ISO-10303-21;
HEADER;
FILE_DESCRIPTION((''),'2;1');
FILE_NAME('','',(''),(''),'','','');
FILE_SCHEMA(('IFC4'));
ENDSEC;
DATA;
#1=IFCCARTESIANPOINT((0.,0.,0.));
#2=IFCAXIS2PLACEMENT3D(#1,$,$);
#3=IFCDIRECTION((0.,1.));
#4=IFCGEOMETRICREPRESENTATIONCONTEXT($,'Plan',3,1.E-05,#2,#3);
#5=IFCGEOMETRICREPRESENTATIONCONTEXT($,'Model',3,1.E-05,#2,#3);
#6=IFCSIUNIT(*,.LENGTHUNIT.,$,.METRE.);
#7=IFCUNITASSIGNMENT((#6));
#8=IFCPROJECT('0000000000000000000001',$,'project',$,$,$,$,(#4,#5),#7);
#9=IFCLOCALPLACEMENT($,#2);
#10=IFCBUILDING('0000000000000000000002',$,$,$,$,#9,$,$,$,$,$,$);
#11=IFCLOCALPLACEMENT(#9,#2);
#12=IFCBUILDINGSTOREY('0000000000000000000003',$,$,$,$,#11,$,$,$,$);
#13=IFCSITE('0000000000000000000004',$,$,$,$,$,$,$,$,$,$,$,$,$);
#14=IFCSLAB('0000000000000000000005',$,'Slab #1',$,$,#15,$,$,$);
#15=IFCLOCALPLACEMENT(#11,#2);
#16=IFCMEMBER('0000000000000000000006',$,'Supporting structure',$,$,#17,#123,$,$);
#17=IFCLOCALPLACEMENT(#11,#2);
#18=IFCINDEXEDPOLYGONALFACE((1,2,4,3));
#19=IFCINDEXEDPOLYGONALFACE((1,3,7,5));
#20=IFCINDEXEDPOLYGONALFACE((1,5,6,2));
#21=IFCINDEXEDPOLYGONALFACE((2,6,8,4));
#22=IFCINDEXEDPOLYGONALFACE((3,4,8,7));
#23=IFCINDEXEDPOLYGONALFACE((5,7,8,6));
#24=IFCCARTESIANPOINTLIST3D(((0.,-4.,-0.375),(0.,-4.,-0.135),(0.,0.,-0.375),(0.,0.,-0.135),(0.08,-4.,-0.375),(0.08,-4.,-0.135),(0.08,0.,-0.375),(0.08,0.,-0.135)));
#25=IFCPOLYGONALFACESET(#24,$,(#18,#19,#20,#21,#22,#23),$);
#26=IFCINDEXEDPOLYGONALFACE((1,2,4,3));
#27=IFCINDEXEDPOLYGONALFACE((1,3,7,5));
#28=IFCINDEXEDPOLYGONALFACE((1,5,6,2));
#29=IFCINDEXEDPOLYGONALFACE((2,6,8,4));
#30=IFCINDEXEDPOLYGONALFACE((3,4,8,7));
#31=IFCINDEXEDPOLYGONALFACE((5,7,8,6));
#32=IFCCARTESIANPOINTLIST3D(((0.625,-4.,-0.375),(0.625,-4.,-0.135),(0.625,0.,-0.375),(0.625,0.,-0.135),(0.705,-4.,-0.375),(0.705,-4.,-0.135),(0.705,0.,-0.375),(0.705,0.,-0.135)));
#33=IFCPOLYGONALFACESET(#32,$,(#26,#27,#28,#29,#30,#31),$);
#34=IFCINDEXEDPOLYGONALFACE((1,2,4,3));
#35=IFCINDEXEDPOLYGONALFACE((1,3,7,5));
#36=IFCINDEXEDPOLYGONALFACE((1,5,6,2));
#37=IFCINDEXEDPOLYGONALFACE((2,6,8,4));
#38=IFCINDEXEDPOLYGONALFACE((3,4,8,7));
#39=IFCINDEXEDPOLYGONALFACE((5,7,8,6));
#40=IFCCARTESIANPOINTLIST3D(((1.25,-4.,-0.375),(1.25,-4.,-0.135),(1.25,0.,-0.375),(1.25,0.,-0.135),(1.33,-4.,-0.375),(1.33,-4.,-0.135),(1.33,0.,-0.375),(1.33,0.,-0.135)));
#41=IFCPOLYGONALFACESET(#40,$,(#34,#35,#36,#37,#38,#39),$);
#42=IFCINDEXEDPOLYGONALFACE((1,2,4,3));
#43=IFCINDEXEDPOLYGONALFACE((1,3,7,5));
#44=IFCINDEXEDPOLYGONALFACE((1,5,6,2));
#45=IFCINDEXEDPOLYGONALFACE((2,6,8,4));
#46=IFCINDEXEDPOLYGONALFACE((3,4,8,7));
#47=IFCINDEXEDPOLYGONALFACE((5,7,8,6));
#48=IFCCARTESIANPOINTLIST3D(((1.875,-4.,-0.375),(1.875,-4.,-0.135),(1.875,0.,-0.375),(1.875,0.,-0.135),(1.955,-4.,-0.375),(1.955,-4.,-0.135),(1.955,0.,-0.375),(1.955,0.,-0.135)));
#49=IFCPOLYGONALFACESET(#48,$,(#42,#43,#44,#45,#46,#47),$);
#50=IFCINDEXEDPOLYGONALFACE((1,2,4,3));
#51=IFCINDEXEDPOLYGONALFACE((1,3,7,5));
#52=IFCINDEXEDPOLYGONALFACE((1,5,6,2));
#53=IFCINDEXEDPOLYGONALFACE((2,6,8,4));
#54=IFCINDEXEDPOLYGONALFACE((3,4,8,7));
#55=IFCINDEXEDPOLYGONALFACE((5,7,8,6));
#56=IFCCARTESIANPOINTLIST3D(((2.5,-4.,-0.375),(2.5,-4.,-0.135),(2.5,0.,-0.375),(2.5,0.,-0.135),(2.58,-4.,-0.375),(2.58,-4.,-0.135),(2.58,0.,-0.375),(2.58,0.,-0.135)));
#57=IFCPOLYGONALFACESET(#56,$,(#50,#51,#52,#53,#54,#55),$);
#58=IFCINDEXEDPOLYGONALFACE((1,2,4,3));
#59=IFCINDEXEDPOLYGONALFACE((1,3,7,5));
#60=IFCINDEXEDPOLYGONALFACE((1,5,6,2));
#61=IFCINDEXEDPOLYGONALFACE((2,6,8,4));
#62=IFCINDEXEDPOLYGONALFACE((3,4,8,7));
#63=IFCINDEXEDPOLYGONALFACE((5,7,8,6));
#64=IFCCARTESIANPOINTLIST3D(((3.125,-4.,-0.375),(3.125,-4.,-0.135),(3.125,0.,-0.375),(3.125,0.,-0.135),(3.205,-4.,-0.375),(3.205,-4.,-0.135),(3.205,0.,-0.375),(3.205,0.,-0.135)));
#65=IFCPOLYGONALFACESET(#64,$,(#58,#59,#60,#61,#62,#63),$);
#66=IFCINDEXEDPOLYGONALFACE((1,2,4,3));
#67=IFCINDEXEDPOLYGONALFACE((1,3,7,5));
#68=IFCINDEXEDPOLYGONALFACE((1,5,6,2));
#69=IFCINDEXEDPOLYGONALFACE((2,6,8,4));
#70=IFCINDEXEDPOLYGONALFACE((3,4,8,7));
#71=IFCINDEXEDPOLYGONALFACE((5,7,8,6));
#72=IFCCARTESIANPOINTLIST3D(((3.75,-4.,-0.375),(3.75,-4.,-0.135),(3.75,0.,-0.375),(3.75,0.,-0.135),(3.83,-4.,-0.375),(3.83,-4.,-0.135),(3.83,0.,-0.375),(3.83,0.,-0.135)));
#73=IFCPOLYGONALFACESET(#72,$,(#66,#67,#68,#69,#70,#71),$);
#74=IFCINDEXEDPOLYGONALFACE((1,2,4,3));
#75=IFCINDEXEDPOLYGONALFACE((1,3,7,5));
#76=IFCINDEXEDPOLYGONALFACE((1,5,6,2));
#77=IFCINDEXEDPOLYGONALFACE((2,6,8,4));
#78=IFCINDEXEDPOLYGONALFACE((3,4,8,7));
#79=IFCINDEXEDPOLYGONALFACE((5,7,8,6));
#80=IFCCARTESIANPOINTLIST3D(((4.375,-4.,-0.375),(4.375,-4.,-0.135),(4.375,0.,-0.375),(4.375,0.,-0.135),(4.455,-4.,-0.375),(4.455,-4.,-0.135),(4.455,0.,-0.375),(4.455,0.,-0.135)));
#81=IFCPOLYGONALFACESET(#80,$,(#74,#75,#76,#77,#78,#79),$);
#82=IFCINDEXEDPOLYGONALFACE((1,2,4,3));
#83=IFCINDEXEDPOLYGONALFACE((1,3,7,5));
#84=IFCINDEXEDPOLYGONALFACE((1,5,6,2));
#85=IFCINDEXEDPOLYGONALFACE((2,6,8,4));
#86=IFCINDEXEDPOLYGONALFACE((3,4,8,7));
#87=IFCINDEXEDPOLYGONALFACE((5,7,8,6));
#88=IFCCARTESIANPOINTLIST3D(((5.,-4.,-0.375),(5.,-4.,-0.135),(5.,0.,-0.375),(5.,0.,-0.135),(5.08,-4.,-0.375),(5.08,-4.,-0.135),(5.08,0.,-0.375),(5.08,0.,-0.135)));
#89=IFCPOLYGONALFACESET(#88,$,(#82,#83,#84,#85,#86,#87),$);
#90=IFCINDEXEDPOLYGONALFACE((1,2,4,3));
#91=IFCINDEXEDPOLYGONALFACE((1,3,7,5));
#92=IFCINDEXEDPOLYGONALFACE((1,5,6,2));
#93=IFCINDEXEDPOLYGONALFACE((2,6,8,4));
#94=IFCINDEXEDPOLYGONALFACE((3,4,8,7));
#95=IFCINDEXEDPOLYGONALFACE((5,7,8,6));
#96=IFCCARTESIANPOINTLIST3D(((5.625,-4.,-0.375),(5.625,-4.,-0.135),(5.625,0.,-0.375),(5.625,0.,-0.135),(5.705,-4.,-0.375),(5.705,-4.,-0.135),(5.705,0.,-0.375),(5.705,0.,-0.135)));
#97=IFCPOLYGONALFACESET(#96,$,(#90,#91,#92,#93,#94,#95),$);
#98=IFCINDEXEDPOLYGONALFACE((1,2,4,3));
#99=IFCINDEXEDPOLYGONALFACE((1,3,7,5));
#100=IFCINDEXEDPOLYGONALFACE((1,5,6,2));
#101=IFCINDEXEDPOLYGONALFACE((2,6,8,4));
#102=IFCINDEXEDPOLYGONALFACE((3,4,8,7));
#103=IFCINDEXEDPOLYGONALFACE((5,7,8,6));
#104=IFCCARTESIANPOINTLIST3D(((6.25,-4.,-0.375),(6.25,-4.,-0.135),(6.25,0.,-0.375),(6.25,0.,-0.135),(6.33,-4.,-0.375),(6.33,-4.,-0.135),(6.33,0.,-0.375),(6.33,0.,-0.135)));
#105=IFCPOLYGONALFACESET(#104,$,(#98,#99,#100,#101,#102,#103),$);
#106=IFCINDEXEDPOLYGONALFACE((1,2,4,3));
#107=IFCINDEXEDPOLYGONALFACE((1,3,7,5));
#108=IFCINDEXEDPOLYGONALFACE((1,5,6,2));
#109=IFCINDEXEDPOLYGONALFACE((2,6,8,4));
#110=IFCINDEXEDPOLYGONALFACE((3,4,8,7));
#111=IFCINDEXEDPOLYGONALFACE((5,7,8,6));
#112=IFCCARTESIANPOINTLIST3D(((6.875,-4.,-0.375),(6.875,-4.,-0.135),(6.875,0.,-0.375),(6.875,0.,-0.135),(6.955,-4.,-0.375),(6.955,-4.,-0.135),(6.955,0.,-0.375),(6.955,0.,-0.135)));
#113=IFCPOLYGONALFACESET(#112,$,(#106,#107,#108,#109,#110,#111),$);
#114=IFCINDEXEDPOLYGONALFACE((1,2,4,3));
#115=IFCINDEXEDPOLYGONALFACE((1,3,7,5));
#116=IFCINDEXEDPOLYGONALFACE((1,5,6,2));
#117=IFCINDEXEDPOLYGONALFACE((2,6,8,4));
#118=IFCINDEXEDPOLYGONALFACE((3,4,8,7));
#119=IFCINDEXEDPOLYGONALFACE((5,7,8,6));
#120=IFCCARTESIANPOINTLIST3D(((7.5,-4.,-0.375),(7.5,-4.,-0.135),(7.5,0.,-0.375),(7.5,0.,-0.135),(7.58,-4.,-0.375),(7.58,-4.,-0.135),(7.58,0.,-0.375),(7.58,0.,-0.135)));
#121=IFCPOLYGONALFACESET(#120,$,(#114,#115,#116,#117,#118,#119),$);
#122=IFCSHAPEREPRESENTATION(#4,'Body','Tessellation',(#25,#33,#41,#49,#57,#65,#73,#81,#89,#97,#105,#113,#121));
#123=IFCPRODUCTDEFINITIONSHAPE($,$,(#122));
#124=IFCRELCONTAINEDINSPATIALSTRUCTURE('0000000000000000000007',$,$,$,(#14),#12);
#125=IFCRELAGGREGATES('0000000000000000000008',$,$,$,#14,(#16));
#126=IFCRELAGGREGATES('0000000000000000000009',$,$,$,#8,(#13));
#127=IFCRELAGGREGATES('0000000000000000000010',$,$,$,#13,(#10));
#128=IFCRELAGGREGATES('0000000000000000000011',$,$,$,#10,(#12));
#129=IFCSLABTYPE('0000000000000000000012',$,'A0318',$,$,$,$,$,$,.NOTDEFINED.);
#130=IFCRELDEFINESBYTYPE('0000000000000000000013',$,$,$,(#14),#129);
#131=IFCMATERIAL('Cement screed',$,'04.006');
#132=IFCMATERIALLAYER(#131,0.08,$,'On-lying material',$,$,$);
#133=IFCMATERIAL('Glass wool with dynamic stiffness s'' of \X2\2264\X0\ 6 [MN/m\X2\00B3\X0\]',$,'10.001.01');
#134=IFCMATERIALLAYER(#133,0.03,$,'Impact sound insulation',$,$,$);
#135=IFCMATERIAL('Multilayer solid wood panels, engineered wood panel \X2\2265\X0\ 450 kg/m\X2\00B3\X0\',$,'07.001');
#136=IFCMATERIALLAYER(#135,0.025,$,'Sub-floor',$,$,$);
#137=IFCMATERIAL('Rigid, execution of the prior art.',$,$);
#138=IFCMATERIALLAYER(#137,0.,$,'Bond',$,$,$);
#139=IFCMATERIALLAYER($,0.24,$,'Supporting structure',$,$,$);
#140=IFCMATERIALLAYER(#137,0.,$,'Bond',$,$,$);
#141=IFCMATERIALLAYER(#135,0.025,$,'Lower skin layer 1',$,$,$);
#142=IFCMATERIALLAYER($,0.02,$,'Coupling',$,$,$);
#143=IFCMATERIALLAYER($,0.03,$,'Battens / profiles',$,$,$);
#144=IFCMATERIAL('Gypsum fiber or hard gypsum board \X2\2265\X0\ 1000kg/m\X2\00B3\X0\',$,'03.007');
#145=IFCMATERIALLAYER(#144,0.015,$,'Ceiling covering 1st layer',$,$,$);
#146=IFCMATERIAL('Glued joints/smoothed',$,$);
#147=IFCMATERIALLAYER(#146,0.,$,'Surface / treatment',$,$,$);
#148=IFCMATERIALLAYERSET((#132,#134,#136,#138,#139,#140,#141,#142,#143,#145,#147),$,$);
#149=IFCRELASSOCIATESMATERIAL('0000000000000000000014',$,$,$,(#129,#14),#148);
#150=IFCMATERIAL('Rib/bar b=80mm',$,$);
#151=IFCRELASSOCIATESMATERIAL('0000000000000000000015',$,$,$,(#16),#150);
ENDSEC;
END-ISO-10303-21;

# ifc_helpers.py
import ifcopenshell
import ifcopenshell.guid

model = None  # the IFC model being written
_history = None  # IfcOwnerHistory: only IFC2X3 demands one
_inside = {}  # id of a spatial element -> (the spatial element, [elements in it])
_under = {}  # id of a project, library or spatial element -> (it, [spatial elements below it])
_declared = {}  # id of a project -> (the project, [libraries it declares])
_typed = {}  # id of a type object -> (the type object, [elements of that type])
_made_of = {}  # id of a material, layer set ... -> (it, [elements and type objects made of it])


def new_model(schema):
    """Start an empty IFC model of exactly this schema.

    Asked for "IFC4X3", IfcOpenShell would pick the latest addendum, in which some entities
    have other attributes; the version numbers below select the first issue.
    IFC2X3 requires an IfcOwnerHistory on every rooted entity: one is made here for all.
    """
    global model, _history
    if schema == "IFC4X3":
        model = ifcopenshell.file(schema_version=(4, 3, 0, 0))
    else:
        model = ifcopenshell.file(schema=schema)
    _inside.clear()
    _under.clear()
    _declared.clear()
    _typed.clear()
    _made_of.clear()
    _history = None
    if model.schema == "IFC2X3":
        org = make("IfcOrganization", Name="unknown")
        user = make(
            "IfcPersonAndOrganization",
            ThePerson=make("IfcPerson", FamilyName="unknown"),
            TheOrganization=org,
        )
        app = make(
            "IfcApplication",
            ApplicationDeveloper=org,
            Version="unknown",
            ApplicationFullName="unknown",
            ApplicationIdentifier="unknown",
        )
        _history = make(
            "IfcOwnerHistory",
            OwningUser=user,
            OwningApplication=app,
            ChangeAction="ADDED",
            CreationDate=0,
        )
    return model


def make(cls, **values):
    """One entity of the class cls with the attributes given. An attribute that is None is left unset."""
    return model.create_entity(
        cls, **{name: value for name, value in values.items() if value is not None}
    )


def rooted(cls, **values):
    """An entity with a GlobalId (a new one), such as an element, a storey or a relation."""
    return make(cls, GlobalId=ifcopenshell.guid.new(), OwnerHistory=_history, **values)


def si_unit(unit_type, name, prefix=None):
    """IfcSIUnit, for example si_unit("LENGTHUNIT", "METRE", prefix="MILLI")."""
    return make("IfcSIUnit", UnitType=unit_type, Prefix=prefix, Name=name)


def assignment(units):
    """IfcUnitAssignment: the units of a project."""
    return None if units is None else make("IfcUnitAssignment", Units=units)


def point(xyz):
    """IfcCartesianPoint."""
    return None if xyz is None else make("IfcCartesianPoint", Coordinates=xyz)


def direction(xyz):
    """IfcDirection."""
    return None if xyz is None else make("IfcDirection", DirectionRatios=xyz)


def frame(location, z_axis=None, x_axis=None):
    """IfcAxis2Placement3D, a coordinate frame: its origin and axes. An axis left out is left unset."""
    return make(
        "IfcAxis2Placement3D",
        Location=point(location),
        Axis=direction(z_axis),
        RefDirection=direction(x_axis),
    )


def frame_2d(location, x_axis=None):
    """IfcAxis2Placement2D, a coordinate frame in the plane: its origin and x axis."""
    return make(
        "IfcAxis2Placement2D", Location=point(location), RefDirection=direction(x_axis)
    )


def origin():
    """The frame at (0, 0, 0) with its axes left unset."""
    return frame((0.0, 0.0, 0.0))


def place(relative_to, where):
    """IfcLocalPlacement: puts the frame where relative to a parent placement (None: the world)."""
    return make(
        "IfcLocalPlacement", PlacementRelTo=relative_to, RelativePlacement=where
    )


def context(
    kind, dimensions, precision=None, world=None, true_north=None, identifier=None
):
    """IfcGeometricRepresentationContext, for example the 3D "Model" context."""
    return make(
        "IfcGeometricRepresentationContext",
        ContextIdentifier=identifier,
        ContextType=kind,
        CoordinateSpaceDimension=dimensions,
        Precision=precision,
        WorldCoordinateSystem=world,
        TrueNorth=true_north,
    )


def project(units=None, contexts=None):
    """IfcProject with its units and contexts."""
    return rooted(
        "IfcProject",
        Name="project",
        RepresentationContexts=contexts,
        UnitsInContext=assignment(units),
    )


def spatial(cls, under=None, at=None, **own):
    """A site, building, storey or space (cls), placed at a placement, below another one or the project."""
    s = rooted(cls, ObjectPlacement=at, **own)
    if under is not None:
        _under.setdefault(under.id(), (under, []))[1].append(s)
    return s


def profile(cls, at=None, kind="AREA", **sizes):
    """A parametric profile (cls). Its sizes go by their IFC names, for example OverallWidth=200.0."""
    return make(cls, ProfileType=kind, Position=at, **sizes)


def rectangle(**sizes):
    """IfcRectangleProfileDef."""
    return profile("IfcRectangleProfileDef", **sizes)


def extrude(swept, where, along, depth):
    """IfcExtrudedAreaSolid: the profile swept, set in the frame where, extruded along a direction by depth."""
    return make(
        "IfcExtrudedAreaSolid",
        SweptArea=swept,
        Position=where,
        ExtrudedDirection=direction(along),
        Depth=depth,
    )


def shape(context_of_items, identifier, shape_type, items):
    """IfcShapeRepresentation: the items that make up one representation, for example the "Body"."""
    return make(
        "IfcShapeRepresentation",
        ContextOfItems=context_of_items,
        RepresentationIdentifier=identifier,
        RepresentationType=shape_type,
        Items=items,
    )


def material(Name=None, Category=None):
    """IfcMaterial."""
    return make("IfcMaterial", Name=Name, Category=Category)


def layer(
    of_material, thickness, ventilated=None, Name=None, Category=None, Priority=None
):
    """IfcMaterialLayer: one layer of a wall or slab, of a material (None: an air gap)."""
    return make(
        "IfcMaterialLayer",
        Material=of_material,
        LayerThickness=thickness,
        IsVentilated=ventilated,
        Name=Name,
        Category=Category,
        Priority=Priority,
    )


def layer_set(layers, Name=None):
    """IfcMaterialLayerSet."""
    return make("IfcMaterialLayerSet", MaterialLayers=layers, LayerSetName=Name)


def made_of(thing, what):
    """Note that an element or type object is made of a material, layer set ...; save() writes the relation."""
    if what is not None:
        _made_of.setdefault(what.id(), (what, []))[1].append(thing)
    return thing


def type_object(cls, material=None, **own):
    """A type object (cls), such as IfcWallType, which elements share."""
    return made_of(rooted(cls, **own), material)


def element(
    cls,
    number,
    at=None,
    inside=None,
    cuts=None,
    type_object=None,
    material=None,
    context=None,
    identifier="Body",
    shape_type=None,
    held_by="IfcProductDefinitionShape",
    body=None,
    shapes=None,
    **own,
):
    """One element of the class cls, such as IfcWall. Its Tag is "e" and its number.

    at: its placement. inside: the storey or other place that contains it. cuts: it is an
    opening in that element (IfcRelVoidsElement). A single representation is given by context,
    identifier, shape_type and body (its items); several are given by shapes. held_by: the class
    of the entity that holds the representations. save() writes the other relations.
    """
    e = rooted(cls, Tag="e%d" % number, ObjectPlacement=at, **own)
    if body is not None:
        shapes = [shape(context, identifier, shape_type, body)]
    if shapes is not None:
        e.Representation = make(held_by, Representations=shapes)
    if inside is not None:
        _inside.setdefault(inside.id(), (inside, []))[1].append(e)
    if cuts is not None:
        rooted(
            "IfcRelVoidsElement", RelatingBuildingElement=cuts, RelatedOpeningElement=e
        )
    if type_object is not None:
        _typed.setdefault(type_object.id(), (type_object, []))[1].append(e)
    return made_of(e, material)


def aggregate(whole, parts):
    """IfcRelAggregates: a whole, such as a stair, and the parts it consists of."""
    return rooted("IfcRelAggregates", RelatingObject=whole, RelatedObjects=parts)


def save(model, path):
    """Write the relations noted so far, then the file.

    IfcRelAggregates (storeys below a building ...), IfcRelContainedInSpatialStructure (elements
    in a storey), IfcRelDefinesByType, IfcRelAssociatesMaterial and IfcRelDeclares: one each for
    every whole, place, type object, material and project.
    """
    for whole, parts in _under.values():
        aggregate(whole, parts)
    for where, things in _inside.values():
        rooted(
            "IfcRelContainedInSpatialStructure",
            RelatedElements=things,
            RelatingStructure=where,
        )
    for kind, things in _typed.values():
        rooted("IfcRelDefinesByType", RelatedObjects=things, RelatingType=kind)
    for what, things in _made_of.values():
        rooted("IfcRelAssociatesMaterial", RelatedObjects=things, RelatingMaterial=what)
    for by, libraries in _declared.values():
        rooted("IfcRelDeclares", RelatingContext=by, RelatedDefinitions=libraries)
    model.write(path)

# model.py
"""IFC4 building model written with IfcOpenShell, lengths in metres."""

from ifc_helpers import new_model, si_unit, direction, frame, frame_2d, origin, place, context, project, spatial, rectangle, extrude, material, layer, layer_set, type_object, element, aggregate, save


model = new_model("IFC4")

# Units and contexts
plan_context = context("Plan", 3, precision=1e-05, world=origin(), true_north=direction((0.0, 1.0)))
model_context = context("Model", 3, precision=1e-05, world=origin(), true_north=direction((0.0, 1.0)))
ifc_project = project(units=[si_unit("LENGTHUNIT", "METRE")], contexts=[plan_context, model_context])

# Site, building, storey
site = spatial("IfcSite", under=ifc_project)
building_placement = place(None, origin())
building = spatial("IfcBuilding", under=site, at=building_placement)
storey_placement = place(building_placement, origin())
storey = spatial("IfcBuildingStorey", under=building, at=storey_placement)

# Slab, member
ifc_material_1 = material(Name="Cement screed", Category="04.006")
ifc_layer_1 = layer(ifc_material_1, 0.08, Name="On-lying material")
ifc_material_2 = material(Name="Glass wool with dynamic stiffness s' of ≤ 6 [MN/m³]", Category="10.001.01")
ifc_layer_2 = layer(ifc_material_2, 0.03, Name="Impact sound insulation")
ifc_material_3 = material(Name="Multilayer solid wood panels, engineered wood panel ≥ 450 kg/m³", Category="07.001")
ifc_layer_3 = layer(ifc_material_3, 0.025, Name="Sub-floor")
ifc_material_4 = material(Name="Rigid, execution of the prior art.")
ifc_layer_4 = layer(ifc_material_4, 0.0, Name="Bond")
ifc_layer_5 = layer(None, 0.24, Name="Supporting structure")
ifc_layer_6 = layer(ifc_material_4, 0.0, Name="Bond")
ifc_layer_7 = layer(ifc_material_3, 0.025, Name="Lower skin layer 1")
ifc_layer_8 = layer(None, 0.02, Name="Coupling")
ifc_layer_9 = layer(None, 0.03, Name="Battens / profiles")
ifc_material_5 = material(Name="Gypsum fiber or hard gypsum board ≥ 1000kg/m³", Category="03.007")
ifc_layer_10 = layer(ifc_material_5, 0.015, Name="Ceiling covering 1st layer")
ifc_material_6 = material(Name="Glued joints/smoothed")
ifc_layer_11 = layer(ifc_material_6, 0.0, Name="Surface / treatment")
ifc_layer_set = layer_set([ifc_layer_1, ifc_layer_2, ifc_layer_3, ifc_layer_4, ifc_layer_5, ifc_layer_6, ifc_layer_7, ifc_layer_8, ifc_layer_9, ifc_layer_10, ifc_layer_11])
slab_type = type_object("IfcSlabType", Name="A0318", PredefinedType="NOTDEFINED", material=ifc_layer_set)
slab_placement = place(None, frame((0.0, 0.0, 0.0), z_axis=(0.0, 0.0, -1.0), x_axis=(1.0, 0.0, 0.0)))
slab = element("IfcSlab", 1, at=slab_placement, inside=storey, type_object=slab_type, material=ifc_layer_set, Name="Slab #1")
ifc_material_7 = material(Name="Rib/bar b=80mm")
member_1_placement = place(slab_placement, origin())
member_1 = element("IfcMember", 2, at=member_1_placement, material=ifc_material_7, Name="Supporting structure", context=plan_context, shape_type="SweptSolid", body=[
    extrude(rectangle(XDim=0.08, YDim=0.24, at=frame_2d((0.04, 0.12), x_axis=(1.0, 0.0))), frame((0.0, 4.0, 0.135), z_axis=(0.0, -1.0, 0.0), x_axis=(1.0, 0.0, 0.0)), (0.0, 0.0, 1.0), 4.0),
    extrude(rectangle(XDim=0.08, YDim=0.24, at=frame_2d((0.04, 0.12), x_axis=(1.0, 0.0))), frame((0.625, 4.0, 0.135), z_axis=(0.0, -1.0, 0.0), x_axis=(1.0, 0.0, 0.0)), (0.0, 0.0, 1.0), 4.0),
    extrude(rectangle(XDim=0.08, YDim=0.24, at=frame_2d((0.04, 0.12), x_axis=(1.0, 0.0))), frame((1.25, 4.0, 0.135), z_axis=(0.0, -1.0, 0.0), x_axis=(1.0, 0.0, 0.0)), (0.0, 0.0, 1.0), 4.0),
    extrude(rectangle(XDim=0.08, YDim=0.24, at=frame_2d((0.04, 0.12), x_axis=(1.0, 0.0))), frame((1.875, 4.0, 0.135), z_axis=(0.0, -1.0, 0.0), x_axis=(1.0, 0.0, 0.0)), (0.0, 0.0, 1.0), 4.0),
    extrude(rectangle(XDim=0.08, YDim=0.24, at=frame_2d((0.04, 0.12), x_axis=(1.0, 0.0))), frame((2.5, 4.0, 0.135), z_axis=(0.0, -1.0, 0.0), x_axis=(1.0, 0.0, 0.0)), (0.0, 0.0, 1.0), 4.0),
    extrude(rectangle(XDim=0.08, YDim=0.24, at=frame_2d((0.04, 0.12), x_axis=(1.0, 0.0))), frame((3.125, 4.0, 0.135), z_axis=(0.0, -1.0, 0.0), x_axis=(1.0, 0.0, 0.0)), (0.0, 0.0, 1.0), 4.0),
    extrude(rectangle(XDim=0.08, YDim=0.24, at=frame_2d((0.04, 0.12), x_axis=(1.0, 0.0))), frame((3.75, 4.0, 0.135), z_axis=(0.0, -1.0, 0.0), x_axis=(1.0, 0.0, 0.0)), (0.0, 0.0, 1.0), 4.0),
    extrude(rectangle(XDim=0.08, YDim=0.24, at=frame_2d((0.04, 0.12), x_axis=(1.0, 0.0))), frame((4.375, 4.0, 0.135), z_axis=(0.0, -1.0, 0.0), x_axis=(1.0, 0.0, 0.0)), (0.0, 0.0, 1.0), 4.0),
    extrude(rectangle(XDim=0.08, YDim=0.24, at=frame_2d((0.04, 0.12), x_axis=(1.0, 0.0))), frame((5.0, 4.0, 0.135), z_axis=(0.0, -1.0, 0.0), x_axis=(1.0, 0.0, 0.0)), (0.0, 0.0, 1.0), 4.0),
    extrude(rectangle(XDim=0.08, YDim=0.24, at=frame_2d((0.04, 0.12), x_axis=(1.0, 0.0))), frame((5.625, 4.0, 0.135), z_axis=(0.0, -1.0, 0.0), x_axis=(1.0, 0.0, 0.0)), (0.0, 0.0, 1.0), 4.0),
    extrude(rectangle(XDim=0.08, YDim=0.24, at=frame_2d((0.04, 0.12), x_axis=(1.0, 0.0))), frame((6.25, 4.0, 0.135), z_axis=(0.0, -1.0, 0.0), x_axis=(1.0, 0.0, 0.0)), (0.0, 0.0, 1.0), 4.0),
    extrude(rectangle(XDim=0.08, YDim=0.24, at=frame_2d((0.04, 0.12), x_axis=(1.0, 0.0))), frame((6.875, 4.0, 0.135), z_axis=(0.0, -1.0, 0.0), x_axis=(1.0, 0.0, 0.0)), (0.0, 0.0, 1.0), 4.0),
    extrude(rectangle(XDim=0.08, YDim=0.24, at=frame_2d((0.04, 0.12), x_axis=(1.0, 0.0))), frame((7.5, 4.0, 0.135), z_axis=(0.0, -1.0, 0.0), x_axis=(1.0, 0.0, 0.0)), (0.0, 0.0, 1.0), 4.0),
])
aggregate(slab, [member_1])

save(model, "model.ifc")
